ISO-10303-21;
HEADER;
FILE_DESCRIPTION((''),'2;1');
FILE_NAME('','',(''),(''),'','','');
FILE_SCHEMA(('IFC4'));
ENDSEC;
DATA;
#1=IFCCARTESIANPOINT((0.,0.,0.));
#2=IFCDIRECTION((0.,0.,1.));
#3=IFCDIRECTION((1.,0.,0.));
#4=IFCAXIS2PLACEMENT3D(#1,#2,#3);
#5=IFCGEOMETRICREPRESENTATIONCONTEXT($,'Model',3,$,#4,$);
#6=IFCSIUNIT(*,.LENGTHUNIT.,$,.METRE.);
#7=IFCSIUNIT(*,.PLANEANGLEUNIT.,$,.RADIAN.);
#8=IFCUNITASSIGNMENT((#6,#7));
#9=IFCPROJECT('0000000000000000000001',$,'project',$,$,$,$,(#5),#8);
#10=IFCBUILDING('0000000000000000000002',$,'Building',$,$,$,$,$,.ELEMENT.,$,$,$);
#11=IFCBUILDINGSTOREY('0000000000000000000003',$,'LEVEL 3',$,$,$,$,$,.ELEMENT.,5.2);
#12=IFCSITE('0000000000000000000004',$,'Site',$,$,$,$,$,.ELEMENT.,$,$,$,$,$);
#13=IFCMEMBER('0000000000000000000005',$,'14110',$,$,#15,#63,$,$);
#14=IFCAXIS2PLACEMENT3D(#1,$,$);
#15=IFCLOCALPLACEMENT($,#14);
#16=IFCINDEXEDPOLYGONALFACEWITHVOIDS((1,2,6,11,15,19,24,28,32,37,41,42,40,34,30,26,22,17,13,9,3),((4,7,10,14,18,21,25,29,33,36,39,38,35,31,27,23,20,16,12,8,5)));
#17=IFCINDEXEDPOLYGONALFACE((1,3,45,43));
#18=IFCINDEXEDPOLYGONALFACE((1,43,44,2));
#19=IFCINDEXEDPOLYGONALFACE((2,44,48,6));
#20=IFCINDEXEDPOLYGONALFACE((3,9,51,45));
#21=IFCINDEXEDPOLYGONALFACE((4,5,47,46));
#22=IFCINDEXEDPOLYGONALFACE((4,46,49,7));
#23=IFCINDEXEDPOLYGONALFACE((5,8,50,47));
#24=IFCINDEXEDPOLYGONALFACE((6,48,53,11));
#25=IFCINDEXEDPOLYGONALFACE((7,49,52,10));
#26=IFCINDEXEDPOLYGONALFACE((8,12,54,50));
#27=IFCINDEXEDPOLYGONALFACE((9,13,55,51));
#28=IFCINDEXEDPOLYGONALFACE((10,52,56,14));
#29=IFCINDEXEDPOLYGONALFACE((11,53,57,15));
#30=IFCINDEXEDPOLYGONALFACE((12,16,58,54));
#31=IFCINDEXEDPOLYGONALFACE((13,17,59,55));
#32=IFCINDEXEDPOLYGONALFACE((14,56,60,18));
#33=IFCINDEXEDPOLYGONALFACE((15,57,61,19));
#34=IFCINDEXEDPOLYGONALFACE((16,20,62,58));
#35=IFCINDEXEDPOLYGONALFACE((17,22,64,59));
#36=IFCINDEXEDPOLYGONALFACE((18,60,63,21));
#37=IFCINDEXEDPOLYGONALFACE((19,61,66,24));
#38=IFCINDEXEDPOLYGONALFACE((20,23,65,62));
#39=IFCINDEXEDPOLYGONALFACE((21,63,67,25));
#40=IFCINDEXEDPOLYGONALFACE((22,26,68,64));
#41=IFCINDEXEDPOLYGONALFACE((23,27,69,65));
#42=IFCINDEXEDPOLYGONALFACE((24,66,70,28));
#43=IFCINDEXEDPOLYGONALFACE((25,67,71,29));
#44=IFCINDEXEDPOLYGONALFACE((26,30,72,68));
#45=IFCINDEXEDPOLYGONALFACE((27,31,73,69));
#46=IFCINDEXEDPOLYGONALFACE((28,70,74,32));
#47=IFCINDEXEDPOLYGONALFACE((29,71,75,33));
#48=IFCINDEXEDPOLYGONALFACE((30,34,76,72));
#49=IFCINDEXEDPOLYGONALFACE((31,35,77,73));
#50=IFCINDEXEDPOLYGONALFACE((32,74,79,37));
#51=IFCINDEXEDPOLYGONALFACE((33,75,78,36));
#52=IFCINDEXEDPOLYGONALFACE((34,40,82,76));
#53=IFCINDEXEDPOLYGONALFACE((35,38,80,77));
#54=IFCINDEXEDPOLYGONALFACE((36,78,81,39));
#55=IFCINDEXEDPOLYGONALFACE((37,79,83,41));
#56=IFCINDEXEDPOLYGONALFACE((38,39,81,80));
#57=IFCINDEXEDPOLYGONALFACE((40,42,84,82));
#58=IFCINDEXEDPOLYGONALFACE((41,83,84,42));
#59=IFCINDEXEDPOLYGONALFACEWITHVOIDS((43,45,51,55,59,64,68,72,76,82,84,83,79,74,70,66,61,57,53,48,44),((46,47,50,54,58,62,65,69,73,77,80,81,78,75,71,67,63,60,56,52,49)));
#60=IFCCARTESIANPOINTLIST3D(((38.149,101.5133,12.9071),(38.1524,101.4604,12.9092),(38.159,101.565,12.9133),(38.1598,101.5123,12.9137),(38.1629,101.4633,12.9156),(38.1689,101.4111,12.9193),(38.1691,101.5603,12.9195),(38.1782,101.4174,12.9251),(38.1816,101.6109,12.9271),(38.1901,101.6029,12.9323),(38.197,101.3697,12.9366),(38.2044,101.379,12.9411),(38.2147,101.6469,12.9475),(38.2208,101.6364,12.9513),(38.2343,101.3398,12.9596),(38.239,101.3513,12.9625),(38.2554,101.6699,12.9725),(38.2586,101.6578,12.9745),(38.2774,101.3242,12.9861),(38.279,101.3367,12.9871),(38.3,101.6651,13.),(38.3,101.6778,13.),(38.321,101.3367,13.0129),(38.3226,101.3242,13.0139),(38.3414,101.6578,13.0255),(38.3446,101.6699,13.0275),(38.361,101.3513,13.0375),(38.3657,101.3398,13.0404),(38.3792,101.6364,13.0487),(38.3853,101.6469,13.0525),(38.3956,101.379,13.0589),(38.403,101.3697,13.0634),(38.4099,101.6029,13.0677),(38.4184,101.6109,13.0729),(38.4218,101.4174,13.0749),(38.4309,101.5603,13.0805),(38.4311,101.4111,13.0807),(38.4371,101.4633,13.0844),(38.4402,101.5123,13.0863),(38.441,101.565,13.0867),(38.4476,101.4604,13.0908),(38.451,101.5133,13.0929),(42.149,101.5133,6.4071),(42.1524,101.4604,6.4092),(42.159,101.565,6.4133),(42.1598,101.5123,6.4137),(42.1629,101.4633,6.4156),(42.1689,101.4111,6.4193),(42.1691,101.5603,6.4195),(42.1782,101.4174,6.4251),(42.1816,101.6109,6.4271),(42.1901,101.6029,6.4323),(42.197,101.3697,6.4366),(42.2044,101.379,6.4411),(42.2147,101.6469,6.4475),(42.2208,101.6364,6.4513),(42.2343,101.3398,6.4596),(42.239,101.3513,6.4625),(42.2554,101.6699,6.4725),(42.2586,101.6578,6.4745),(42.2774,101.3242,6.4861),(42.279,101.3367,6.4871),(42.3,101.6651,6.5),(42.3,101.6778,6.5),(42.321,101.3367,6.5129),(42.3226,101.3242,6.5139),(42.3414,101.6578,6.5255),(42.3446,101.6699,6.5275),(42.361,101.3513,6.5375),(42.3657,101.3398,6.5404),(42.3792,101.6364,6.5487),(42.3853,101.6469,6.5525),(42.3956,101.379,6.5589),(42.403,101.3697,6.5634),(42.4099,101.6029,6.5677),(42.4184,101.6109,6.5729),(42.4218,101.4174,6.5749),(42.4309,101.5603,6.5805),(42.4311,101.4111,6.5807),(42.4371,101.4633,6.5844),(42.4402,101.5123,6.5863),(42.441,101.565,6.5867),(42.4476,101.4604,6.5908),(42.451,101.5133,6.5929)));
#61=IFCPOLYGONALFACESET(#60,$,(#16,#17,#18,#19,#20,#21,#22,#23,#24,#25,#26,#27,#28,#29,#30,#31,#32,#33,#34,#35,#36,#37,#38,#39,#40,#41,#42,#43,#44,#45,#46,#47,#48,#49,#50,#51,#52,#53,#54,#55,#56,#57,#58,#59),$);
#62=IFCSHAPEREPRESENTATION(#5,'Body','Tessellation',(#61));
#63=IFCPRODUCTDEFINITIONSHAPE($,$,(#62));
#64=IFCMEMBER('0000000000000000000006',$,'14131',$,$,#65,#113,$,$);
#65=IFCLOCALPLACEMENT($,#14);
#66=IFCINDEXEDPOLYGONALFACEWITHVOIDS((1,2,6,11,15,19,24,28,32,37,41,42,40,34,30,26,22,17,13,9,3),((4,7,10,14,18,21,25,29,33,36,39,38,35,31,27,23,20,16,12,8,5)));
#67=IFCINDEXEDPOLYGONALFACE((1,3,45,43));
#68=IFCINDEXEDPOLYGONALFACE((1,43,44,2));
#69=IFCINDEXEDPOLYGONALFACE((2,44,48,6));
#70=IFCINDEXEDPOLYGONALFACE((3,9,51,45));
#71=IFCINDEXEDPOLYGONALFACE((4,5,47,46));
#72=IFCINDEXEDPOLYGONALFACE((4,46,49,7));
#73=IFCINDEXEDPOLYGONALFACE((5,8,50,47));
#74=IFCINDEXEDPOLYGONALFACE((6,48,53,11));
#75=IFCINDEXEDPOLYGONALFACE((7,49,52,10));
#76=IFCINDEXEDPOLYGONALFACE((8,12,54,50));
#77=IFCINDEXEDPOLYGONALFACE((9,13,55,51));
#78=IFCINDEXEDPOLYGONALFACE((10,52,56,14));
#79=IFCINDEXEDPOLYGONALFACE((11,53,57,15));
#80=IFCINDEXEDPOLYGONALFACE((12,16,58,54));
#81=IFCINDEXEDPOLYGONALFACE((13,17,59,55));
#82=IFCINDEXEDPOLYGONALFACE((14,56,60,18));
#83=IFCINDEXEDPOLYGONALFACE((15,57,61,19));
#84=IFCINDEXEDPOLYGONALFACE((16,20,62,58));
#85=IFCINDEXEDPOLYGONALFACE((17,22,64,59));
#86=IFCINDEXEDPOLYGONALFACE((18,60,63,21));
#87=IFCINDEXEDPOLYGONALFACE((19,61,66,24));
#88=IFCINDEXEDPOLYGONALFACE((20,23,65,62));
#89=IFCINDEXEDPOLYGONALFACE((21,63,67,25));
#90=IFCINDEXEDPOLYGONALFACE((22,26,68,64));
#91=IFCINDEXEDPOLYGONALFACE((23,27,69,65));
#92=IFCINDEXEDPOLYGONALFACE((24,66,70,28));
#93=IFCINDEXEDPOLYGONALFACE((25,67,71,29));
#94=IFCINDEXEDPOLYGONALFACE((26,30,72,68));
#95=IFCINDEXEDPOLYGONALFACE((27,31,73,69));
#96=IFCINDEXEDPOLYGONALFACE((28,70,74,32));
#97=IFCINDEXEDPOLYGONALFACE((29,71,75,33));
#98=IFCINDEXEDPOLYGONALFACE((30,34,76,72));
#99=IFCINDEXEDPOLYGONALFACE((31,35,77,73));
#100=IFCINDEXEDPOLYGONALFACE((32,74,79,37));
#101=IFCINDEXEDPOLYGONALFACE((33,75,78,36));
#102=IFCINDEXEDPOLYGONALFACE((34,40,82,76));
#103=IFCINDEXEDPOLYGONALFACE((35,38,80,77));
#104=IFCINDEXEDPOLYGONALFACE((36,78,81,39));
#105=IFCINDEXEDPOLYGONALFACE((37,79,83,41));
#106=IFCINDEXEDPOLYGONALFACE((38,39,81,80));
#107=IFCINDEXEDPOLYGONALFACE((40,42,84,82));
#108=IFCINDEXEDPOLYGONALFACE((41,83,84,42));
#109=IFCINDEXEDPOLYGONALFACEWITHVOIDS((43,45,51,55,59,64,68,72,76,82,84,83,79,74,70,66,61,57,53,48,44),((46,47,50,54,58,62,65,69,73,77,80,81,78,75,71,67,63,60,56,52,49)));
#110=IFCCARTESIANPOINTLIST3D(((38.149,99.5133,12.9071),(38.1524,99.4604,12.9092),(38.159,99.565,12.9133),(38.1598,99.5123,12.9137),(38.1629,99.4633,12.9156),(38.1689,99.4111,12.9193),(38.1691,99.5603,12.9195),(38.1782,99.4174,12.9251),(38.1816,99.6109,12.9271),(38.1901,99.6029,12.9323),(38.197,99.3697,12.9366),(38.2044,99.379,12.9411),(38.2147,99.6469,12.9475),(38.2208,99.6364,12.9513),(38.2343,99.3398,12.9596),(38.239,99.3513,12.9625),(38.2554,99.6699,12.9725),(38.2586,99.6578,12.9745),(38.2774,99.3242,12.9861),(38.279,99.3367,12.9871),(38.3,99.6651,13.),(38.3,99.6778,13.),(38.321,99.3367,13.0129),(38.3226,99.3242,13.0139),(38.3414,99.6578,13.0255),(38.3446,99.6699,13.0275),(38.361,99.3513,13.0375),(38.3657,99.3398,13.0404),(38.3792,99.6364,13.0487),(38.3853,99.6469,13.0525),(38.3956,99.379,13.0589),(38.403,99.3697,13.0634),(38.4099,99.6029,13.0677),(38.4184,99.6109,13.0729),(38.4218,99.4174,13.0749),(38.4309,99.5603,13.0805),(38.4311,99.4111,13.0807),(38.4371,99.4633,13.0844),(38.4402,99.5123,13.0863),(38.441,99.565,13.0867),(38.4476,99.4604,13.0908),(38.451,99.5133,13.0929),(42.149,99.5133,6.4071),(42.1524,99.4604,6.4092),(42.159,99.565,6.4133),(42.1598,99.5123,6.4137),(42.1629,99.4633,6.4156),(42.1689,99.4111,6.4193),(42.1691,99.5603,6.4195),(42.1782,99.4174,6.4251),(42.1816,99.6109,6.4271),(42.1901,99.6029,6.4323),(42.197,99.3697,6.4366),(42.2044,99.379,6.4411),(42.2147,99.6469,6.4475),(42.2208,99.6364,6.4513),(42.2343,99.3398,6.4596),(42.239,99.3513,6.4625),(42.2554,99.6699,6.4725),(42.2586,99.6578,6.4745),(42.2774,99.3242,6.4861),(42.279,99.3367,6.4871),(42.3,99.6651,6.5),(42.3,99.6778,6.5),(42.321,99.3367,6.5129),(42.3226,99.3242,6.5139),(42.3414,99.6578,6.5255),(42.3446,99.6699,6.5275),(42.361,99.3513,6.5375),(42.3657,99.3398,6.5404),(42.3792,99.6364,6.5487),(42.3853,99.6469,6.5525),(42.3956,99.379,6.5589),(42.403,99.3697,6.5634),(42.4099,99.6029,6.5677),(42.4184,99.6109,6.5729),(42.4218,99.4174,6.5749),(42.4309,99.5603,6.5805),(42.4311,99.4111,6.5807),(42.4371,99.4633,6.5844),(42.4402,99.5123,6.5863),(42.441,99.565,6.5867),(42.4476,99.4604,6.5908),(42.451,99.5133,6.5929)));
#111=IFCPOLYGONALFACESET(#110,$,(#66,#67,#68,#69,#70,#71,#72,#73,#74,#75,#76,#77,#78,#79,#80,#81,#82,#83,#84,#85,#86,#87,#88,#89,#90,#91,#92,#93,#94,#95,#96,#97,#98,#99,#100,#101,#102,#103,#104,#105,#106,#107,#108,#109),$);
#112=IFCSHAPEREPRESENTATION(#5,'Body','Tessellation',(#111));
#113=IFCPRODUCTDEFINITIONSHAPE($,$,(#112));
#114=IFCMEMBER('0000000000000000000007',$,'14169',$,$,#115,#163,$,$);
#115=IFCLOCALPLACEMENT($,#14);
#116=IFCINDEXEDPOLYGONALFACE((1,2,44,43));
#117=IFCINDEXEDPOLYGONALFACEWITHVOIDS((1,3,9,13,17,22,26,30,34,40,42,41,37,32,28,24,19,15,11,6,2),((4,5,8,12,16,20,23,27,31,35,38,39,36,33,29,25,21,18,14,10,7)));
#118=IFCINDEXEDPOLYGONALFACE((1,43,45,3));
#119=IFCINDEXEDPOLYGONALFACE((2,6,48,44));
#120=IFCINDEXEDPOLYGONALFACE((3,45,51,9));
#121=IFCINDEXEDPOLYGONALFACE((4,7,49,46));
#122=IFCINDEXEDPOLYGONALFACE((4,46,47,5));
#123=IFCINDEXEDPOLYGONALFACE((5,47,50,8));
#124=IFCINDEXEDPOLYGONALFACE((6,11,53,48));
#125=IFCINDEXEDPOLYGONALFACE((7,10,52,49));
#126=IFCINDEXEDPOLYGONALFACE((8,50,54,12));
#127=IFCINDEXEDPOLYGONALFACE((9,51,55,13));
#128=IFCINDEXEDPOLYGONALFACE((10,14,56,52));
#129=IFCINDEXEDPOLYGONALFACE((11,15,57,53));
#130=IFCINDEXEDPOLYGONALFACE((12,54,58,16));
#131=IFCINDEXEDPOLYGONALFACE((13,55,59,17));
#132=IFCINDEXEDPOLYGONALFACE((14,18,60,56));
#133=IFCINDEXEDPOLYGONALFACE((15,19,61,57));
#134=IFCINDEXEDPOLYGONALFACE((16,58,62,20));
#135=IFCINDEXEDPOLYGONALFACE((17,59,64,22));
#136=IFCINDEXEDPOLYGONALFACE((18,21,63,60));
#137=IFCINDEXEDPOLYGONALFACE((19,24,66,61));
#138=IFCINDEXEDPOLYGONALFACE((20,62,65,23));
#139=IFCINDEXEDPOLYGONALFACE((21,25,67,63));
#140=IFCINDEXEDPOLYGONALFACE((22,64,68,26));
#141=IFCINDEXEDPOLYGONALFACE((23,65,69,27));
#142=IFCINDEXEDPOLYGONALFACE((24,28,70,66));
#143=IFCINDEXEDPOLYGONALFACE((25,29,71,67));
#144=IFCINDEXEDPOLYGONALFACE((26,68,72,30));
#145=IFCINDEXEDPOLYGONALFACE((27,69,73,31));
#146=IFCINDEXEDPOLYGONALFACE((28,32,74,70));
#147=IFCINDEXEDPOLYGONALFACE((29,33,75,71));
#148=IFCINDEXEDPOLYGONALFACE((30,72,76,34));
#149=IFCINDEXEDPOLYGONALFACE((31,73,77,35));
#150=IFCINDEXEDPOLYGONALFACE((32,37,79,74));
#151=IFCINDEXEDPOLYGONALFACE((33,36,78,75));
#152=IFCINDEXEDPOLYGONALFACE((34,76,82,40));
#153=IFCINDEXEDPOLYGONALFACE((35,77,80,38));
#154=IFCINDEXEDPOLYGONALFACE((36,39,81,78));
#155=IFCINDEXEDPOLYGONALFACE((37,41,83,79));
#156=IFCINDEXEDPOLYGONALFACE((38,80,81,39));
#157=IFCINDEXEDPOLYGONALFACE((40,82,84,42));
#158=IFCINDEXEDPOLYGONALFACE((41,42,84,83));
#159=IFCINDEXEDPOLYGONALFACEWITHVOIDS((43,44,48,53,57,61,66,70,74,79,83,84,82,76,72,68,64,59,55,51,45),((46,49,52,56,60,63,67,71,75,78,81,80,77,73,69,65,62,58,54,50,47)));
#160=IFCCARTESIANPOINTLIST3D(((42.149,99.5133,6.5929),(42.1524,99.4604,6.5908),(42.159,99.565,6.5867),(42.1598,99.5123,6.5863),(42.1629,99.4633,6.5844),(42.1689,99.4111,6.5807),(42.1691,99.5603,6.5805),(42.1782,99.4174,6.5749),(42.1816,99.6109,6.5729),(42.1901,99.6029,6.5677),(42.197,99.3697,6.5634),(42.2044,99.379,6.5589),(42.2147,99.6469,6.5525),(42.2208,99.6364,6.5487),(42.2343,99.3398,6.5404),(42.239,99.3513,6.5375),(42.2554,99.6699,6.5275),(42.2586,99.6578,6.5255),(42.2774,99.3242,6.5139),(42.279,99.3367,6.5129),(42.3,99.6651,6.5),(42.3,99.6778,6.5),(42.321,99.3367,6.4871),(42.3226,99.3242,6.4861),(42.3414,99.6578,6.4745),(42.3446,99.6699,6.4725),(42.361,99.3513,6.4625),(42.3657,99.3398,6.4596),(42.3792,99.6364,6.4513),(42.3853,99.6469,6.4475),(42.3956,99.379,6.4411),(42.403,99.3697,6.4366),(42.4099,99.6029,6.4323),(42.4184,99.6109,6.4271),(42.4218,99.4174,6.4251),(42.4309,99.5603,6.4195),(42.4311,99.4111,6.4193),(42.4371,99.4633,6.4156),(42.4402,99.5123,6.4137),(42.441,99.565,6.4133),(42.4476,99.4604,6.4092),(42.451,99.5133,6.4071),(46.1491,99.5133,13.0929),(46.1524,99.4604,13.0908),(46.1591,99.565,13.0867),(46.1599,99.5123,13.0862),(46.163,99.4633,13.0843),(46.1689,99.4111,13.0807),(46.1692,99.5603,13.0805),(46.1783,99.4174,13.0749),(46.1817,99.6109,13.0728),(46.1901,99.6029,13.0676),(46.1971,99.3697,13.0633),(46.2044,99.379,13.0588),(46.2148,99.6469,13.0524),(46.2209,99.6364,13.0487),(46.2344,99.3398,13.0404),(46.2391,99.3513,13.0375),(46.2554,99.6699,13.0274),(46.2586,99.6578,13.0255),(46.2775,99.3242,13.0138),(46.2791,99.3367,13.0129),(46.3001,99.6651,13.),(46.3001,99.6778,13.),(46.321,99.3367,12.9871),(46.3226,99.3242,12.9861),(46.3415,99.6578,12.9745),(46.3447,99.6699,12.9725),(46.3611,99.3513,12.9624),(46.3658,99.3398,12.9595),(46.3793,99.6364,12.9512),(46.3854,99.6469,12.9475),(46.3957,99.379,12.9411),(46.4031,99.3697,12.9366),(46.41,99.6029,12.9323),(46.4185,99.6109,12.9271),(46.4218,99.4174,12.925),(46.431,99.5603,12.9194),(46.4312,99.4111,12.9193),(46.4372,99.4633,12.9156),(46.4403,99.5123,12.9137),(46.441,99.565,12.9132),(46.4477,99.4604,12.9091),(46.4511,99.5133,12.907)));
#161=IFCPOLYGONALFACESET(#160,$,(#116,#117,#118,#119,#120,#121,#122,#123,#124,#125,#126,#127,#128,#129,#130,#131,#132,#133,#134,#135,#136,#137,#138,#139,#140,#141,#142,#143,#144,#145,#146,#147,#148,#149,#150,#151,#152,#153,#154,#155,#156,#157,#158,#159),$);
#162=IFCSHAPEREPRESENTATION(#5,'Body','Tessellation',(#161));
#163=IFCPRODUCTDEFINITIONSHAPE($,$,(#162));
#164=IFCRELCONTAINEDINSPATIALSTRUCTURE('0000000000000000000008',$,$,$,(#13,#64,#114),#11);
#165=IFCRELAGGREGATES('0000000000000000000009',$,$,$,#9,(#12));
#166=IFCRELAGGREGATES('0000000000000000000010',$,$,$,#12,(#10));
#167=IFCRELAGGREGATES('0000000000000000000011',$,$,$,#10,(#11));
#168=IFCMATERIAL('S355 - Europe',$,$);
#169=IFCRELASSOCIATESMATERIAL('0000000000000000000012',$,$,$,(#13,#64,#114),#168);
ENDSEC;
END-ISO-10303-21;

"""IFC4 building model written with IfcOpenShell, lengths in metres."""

from ifc_helpers import new_model, si_unit, frame, origin_with_axes, origin_2d_with_axis, place, context, project, spatial, hollow_circle, extrude, material, material_profile, profile_set, profile_usage, element, save


model = new_model("IFC4")

# Units and contexts
model_context = context("Model", 3, world=origin_with_axes())
ifc_project = project(units=[si_unit("LENGTHUNIT", "METRE"), si_unit("PLANEANGLEUNIT", "RADIAN")], contexts=[model_context])

# Site, building, storey
site = spatial("IfcSite", under=ifc_project, Name="Site", CompositionType="ELEMENT")
building = spatial("IfcBuilding", under=site, Name="Building", CompositionType="ELEMENT")
storey = spatial("IfcBuildingStorey", under=building, Name="LEVEL 3", CompositionType="ELEMENT", Elevation=5.2)

# Shared definitions
ifc_material = material(Name="S355 - Europe")

# Members
ifc_material_profile_1 = material_profile(ifc_material, hollow_circle(Radius=0.1778, WallThickness=0.0127, at=origin_2d_with_axis()))
ifc_profile_set_1 = profile_set([ifc_material_profile_1])
ifc_profile_usage_1 = profile_usage(ifc_profile_set_1, cardinal=10)
member_1_placement = place(None, frame((38.3, 101.5, 13.0), z_axis=(0.524097, 0.0, -0.851658), x_axis=(0.0, 1.0, 0.0)))
element("IfcMember", 1, at=member_1_placement, inside=storey, material=ifc_profile_usage_1, Name="14110", context=model_context, shape_type="SweptSolid", body=[
    extrude(hollow_circle(Radius=0.1778, WallThickness=0.0127, at=origin_2d_with_axis()), origin_with_axes(), (0.0, 0.0, 1.0), 7.6322),
])
ifc_material_profile_2 = material_profile(ifc_material, hollow_circle(Radius=0.1778, WallThickness=0.0127, at=origin_2d_with_axis()))
ifc_profile_set_2 = profile_set([ifc_material_profile_2])
ifc_profile_usage_2 = profile_usage(ifc_profile_set_2, cardinal=10)
member_2_placement = place(None, frame((38.3, 99.5, 13.0), z_axis=(0.524097, 0.0, -0.851658), x_axis=(0.0, 1.0, 0.0)))
element("IfcMember", 2, at=member_2_placement, inside=storey, material=ifc_profile_usage_2, Name="14131", context=model_context, shape_type="SweptSolid", body=[
    extrude(hollow_circle(Radius=0.1778, WallThickness=0.0127, at=origin_2d_with_axis()), origin_with_axes(), (0.0, 0.0, 1.0), 7.6322),
])
ifc_material_profile_3 = material_profile(ifc_material, hollow_circle(Radius=0.1778, WallThickness=0.0127, at=origin_2d_with_axis()))
ifc_profile_set_3 = profile_set([ifc_material_profile_3])
ifc_profile_usage_3 = profile_usage(ifc_profile_set_3, cardinal=10)
member_3_placement = place(None, frame((42.3, 99.5, 6.5), z_axis=(0.524107, 0.0, 0.851652), x_axis=(0.0, 1.0, 0.0)))
element("IfcMember", 3, at=member_3_placement, inside=storey, material=ifc_profile_usage_3, Name="14169", context=model_context, shape_type="SweptSolid", body=[
    extrude(hollow_circle(Radius=0.1778, WallThickness=0.0127, at=origin_2d_with_axis()), origin_with_axes(), (0.0, 0.0, 1.0), 7.6322),
])

save(model, "model.ifc")
